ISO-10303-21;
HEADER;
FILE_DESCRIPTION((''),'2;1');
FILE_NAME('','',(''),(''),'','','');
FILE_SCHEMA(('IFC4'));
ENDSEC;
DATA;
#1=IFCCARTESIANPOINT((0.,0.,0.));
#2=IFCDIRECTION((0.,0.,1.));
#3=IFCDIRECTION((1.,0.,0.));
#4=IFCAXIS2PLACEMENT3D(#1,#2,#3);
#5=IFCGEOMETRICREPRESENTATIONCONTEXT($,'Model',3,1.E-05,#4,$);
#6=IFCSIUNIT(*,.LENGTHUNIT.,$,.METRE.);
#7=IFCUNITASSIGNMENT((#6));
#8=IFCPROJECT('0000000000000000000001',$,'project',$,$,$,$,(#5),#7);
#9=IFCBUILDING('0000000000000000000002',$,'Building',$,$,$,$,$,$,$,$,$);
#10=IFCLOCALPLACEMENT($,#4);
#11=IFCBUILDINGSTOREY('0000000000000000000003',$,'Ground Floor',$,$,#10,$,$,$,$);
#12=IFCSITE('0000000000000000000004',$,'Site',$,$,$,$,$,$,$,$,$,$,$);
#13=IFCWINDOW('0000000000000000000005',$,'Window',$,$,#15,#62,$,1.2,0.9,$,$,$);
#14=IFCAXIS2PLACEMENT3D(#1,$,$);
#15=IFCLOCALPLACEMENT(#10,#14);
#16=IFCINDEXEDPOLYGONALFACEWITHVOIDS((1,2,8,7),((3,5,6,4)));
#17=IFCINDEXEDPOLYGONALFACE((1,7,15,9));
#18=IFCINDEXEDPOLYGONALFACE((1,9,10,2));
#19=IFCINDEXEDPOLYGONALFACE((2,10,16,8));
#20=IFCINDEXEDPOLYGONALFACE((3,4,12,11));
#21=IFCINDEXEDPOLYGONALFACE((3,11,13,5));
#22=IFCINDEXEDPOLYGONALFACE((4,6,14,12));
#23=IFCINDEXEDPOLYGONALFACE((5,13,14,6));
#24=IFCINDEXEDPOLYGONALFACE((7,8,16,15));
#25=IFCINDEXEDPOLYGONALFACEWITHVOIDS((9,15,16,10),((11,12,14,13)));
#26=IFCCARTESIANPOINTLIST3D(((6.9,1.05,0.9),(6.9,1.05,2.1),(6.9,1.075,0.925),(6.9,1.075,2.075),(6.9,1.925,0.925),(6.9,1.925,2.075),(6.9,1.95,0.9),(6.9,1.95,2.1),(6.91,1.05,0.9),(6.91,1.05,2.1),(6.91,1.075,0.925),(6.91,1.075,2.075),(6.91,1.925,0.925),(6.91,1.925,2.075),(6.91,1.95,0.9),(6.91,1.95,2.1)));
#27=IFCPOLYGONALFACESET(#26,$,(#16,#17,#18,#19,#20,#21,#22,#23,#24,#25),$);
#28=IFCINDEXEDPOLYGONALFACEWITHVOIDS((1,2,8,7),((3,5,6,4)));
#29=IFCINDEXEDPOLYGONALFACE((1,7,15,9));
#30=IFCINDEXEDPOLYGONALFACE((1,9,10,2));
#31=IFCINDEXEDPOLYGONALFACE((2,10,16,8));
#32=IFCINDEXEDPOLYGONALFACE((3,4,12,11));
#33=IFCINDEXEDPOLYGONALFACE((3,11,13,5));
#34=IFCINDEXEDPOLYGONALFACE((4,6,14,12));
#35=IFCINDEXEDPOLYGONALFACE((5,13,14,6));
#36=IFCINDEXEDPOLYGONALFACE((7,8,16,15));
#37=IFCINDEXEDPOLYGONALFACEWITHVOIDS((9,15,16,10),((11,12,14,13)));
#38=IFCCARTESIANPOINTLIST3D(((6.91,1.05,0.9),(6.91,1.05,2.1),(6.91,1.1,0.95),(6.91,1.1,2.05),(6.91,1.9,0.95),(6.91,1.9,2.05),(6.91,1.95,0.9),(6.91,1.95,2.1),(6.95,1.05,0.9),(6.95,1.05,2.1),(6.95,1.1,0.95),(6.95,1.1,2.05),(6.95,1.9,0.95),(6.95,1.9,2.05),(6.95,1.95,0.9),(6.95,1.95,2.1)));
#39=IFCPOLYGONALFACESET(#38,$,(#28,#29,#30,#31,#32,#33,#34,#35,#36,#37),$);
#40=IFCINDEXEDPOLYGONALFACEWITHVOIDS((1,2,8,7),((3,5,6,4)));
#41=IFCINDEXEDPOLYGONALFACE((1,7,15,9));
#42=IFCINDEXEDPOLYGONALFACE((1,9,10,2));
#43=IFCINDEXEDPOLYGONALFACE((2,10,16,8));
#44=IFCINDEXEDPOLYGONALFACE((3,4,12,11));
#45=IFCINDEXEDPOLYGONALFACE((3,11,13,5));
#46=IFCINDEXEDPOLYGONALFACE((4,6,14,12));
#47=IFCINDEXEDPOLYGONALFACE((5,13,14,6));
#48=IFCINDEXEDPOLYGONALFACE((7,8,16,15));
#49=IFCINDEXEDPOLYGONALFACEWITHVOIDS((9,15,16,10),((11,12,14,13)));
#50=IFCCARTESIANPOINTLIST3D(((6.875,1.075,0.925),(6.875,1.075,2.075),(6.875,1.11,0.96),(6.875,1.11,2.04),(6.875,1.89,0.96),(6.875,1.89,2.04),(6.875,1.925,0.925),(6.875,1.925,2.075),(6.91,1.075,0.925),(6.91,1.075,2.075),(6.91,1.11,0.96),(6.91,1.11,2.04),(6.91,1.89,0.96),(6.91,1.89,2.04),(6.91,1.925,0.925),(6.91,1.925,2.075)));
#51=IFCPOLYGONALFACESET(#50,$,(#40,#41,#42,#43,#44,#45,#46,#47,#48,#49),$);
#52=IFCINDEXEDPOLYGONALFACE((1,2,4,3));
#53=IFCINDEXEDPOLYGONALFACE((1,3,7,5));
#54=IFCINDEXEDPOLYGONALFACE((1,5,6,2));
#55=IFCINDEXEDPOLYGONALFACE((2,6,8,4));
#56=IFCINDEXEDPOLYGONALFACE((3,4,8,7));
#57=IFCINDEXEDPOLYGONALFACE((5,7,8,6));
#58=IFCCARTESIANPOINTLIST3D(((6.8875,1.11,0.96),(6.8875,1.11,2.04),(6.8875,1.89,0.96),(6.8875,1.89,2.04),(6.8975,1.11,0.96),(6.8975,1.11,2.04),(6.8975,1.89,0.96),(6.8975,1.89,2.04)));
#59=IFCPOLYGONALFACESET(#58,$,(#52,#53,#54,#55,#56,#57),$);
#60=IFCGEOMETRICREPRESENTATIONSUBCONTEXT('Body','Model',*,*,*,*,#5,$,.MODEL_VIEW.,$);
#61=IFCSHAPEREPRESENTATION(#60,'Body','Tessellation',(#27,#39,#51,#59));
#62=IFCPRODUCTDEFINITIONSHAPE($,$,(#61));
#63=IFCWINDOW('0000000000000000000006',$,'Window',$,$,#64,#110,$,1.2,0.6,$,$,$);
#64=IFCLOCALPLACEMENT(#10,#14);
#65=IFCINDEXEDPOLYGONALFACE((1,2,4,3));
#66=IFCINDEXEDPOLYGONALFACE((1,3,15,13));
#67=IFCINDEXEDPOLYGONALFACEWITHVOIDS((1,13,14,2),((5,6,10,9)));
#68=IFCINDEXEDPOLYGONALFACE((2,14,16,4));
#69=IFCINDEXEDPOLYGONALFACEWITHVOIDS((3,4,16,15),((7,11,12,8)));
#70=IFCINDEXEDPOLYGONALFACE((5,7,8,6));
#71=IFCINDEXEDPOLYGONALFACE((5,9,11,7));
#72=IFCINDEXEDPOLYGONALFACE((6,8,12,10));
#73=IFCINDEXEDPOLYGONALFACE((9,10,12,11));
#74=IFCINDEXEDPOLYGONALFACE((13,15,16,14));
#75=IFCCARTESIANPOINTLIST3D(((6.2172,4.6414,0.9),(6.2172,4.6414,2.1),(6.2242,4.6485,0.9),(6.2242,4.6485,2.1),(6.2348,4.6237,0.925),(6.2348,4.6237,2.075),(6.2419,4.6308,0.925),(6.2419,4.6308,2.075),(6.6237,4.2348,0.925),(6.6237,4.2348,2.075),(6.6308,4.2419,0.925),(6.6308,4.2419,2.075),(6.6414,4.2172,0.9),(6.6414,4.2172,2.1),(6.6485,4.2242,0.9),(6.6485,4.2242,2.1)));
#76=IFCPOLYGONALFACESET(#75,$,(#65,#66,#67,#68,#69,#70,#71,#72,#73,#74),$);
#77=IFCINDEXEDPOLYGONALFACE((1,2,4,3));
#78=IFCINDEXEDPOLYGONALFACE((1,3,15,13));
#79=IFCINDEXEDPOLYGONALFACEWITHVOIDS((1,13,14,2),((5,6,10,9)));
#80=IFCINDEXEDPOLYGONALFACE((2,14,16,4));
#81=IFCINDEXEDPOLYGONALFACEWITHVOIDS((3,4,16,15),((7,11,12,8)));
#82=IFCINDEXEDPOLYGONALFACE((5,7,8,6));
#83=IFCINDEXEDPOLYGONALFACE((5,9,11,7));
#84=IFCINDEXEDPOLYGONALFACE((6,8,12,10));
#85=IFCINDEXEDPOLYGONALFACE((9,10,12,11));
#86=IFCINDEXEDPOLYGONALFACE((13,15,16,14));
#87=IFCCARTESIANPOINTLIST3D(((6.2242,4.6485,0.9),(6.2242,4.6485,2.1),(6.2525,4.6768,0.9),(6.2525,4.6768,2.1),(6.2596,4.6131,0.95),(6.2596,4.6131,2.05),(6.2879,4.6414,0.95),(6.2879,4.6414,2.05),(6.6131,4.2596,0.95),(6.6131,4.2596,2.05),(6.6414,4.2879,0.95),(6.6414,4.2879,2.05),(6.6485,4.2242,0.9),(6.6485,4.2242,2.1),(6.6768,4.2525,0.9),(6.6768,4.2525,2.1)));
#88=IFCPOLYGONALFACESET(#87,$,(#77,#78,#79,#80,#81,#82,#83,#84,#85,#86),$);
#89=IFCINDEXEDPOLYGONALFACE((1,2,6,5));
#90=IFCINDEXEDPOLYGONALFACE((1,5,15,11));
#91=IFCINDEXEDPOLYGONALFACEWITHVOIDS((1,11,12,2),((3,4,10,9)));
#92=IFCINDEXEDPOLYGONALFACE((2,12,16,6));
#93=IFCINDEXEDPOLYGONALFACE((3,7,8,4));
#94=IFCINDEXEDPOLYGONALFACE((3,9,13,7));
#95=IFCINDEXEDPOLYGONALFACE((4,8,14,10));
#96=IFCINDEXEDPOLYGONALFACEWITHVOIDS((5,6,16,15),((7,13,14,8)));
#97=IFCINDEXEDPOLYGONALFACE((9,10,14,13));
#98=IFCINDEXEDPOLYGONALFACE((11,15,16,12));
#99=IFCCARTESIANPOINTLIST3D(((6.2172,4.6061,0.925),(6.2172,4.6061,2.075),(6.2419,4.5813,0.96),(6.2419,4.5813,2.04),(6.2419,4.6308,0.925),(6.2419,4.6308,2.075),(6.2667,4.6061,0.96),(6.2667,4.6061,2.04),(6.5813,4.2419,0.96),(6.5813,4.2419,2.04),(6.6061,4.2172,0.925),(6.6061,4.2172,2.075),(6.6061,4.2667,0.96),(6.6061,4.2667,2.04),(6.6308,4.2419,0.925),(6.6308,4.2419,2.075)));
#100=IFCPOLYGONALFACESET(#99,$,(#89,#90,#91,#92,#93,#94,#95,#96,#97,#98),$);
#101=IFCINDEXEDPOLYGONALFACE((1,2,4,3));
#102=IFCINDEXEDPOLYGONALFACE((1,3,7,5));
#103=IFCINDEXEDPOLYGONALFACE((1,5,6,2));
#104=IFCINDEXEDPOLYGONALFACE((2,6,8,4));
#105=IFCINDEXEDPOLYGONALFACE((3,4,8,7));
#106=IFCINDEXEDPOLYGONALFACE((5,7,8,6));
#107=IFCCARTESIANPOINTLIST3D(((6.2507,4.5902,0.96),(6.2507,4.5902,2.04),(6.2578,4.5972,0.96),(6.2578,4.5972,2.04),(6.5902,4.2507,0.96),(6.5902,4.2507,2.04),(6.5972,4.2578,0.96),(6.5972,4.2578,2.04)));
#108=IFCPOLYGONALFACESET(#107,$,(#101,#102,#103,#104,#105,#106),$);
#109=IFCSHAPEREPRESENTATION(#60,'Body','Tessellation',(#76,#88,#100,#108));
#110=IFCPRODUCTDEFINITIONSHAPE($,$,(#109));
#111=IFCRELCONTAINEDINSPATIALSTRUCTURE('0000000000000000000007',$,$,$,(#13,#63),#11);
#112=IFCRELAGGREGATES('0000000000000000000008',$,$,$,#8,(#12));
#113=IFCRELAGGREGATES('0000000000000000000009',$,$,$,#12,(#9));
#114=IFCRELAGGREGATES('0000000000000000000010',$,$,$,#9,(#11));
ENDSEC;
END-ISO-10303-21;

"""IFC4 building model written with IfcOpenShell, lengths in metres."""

from ifc_helpers import new_model, si_unit, frame, origin_with_axes, place, context, subcontext, project, spatial, line, indexed_curve, outline, extrude, element, save


model = new_model("IFC4")

# Units and contexts
model_context = context("Model", 3, precision=1e-05, world=origin_with_axes())
body_context = subcontext(model_context, "Body", "Model", "MODEL_VIEW")
ifc_project = project(units=[si_unit("LENGTHUNIT", "METRE")], contexts=[model_context])

# Site, building, storey
site = spatial("IfcSite", under=ifc_project, Name="Site")
building = spatial("IfcBuilding", under=site, Name="Building")
storey_placement = place(None, origin_with_axes())
storey = spatial("IfcBuildingStorey", under=building, at=storey_placement, Name="Ground Floor")

# Windows
window_1_placement = place(storey_placement, frame((7.0, 1.05, 0.9), z_axis=(0.0, 0.0, 1.0), x_axis=(0.0, 1.0, 0.0)))
element("IfcWindow", 1, at=window_1_placement, inside=storey, Name="Window", OverallHeight=1.2, OverallWidth=0.9, context=body_context, shape_type="SweptSolid", body=[
    extrude(outline(indexed_curve([(0.0, 0.0), (0.9, 0.0), (0.9, 1.2), (0.0, 1.2)], segments=[line(1, 2, 3, 4, 1)]), holes=[indexed_curve([(0.025, 0.025), (0.875, 0.025), (0.875, 1.175), (0.025, 1.175)], segments=[line(1, 2, 3, 4, 1)])]), frame((0.0, 0.09, 0.0), z_axis=(0.0, -1.0, 0.0), x_axis=(1.0, 0.0, 0.0)), (0.0, 0.0, -1.0), 0.01),
    extrude(outline(indexed_curve([(0.0, 0.0), (0.9, 0.0), (0.9, 1.2), (0.0, 1.2)], segments=[line(1, 2, 3, 4, 1)]), holes=[indexed_curve([(0.05, 0.05), (0.85, 0.05), (0.85, 1.15), (0.05, 1.15)], segments=[line(1, 2, 3, 4, 1)])]), frame((0.0, 0.05, 0.0), z_axis=(0.0, -1.0, 0.0), x_axis=(1.0, 0.0, 0.0)), (0.0, 0.0, -1.0), 0.04),
    extrude(outline(indexed_curve([(0.0, 0.0), (0.85, 0.0), (0.85, 1.15), (0.0, 1.15)], segments=[line(1, 2, 3, 4, 1)]), holes=[indexed_curve([(0.035, 0.035), (0.815, 0.035), (0.815, 1.115), (0.035, 1.115)], segments=[line(1, 2, 3, 4, 1)])]), frame((0.025, 0.09, 0.025), z_axis=(0.0, -1.0, 0.0), x_axis=(1.0, 0.0, 0.0)), (0.0, 0.0, -1.0), 0.035),
    extrude(outline(indexed_curve([(0.035, 0.035), (0.815, 0.035), (0.815, 1.115), (0.035, 1.115)], segments=[line(1, 2, 3, 4, 1)])), frame((0.025, 0.1025, 0.025), z_axis=(0.0, -1.0, 0.0), x_axis=(1.0, 0.0, 0.0)), (0.0, 0.0, -1.0), 0.01),
])
window_2_placement = place(storey_placement, frame((6.7121, 4.2879, 0.9), z_axis=(0.0, 0.0, 1.0), x_axis=(-0.707107, 0.707107, 0.0)))
element("IfcWindow", 2, at=window_2_placement, inside=storey, Name="Window", OverallHeight=1.2, OverallWidth=0.6, context=body_context, shape_type="SweptSolid", body=[
    extrude(outline(indexed_curve([(0.0, 0.0), (0.6, 0.0), (0.6, 1.2), (0.0, 1.2)], segments=[line(1, 2, 3, 4, 1)]), holes=[indexed_curve([(0.025, 0.025), (0.575, 0.025), (0.575, 1.175), (0.025, 1.175)], segments=[line(1, 2, 3, 4, 1)])]), frame((0.0, 0.09, 0.0), z_axis=(0.0, -1.0, 0.0), x_axis=(1.0, 0.0, 0.0)), (0.0, 0.0, -1.0), 0.01),
    extrude(outline(indexed_curve([(0.0, 0.0), (0.6, 0.0), (0.6, 1.2), (0.0, 1.2)], segments=[line(1, 2, 3, 4, 1)]), holes=[indexed_curve([(0.05, 0.05), (0.55, 0.05), (0.55, 1.15), (0.05, 1.15)], segments=[line(1, 2, 3, 4, 1)])]), frame((0.0, 0.05, 0.0), z_axis=(0.0, -1.0, 0.0), x_axis=(1.0, 0.0, 0.0)), (0.0, 0.0, -1.0), 0.04),
    extrude(outline(indexed_curve([(0.0, 0.0), (0.55, 0.0), (0.55, 1.15), (0.0, 1.15)], segments=[line(1, 2, 3, 4, 1)]), holes=[indexed_curve([(0.035, 0.035), (0.515, 0.035), (0.515, 1.115), (0.035, 1.115)], segments=[line(1, 2, 3, 4, 1)])]), frame((0.025, 0.09, 0.025), z_axis=(0.0, -1.0, 0.0), x_axis=(1.0, 0.0, 0.0)), (0.0, 0.0, -1.0), 0.035),
    extrude(outline(indexed_curve([(0.035, 0.035), (0.515, 0.035), (0.515, 1.115), (0.035, 1.115)], segments=[line(1, 2, 3, 4, 1)])), frame((0.025, 0.1025, 0.025), z_axis=(0.0, -1.0, 0.0), x_axis=(1.0, 0.0, 0.0)), (0.0, 0.0, -1.0), 0.01),
])

save(model, "model.ifc")
